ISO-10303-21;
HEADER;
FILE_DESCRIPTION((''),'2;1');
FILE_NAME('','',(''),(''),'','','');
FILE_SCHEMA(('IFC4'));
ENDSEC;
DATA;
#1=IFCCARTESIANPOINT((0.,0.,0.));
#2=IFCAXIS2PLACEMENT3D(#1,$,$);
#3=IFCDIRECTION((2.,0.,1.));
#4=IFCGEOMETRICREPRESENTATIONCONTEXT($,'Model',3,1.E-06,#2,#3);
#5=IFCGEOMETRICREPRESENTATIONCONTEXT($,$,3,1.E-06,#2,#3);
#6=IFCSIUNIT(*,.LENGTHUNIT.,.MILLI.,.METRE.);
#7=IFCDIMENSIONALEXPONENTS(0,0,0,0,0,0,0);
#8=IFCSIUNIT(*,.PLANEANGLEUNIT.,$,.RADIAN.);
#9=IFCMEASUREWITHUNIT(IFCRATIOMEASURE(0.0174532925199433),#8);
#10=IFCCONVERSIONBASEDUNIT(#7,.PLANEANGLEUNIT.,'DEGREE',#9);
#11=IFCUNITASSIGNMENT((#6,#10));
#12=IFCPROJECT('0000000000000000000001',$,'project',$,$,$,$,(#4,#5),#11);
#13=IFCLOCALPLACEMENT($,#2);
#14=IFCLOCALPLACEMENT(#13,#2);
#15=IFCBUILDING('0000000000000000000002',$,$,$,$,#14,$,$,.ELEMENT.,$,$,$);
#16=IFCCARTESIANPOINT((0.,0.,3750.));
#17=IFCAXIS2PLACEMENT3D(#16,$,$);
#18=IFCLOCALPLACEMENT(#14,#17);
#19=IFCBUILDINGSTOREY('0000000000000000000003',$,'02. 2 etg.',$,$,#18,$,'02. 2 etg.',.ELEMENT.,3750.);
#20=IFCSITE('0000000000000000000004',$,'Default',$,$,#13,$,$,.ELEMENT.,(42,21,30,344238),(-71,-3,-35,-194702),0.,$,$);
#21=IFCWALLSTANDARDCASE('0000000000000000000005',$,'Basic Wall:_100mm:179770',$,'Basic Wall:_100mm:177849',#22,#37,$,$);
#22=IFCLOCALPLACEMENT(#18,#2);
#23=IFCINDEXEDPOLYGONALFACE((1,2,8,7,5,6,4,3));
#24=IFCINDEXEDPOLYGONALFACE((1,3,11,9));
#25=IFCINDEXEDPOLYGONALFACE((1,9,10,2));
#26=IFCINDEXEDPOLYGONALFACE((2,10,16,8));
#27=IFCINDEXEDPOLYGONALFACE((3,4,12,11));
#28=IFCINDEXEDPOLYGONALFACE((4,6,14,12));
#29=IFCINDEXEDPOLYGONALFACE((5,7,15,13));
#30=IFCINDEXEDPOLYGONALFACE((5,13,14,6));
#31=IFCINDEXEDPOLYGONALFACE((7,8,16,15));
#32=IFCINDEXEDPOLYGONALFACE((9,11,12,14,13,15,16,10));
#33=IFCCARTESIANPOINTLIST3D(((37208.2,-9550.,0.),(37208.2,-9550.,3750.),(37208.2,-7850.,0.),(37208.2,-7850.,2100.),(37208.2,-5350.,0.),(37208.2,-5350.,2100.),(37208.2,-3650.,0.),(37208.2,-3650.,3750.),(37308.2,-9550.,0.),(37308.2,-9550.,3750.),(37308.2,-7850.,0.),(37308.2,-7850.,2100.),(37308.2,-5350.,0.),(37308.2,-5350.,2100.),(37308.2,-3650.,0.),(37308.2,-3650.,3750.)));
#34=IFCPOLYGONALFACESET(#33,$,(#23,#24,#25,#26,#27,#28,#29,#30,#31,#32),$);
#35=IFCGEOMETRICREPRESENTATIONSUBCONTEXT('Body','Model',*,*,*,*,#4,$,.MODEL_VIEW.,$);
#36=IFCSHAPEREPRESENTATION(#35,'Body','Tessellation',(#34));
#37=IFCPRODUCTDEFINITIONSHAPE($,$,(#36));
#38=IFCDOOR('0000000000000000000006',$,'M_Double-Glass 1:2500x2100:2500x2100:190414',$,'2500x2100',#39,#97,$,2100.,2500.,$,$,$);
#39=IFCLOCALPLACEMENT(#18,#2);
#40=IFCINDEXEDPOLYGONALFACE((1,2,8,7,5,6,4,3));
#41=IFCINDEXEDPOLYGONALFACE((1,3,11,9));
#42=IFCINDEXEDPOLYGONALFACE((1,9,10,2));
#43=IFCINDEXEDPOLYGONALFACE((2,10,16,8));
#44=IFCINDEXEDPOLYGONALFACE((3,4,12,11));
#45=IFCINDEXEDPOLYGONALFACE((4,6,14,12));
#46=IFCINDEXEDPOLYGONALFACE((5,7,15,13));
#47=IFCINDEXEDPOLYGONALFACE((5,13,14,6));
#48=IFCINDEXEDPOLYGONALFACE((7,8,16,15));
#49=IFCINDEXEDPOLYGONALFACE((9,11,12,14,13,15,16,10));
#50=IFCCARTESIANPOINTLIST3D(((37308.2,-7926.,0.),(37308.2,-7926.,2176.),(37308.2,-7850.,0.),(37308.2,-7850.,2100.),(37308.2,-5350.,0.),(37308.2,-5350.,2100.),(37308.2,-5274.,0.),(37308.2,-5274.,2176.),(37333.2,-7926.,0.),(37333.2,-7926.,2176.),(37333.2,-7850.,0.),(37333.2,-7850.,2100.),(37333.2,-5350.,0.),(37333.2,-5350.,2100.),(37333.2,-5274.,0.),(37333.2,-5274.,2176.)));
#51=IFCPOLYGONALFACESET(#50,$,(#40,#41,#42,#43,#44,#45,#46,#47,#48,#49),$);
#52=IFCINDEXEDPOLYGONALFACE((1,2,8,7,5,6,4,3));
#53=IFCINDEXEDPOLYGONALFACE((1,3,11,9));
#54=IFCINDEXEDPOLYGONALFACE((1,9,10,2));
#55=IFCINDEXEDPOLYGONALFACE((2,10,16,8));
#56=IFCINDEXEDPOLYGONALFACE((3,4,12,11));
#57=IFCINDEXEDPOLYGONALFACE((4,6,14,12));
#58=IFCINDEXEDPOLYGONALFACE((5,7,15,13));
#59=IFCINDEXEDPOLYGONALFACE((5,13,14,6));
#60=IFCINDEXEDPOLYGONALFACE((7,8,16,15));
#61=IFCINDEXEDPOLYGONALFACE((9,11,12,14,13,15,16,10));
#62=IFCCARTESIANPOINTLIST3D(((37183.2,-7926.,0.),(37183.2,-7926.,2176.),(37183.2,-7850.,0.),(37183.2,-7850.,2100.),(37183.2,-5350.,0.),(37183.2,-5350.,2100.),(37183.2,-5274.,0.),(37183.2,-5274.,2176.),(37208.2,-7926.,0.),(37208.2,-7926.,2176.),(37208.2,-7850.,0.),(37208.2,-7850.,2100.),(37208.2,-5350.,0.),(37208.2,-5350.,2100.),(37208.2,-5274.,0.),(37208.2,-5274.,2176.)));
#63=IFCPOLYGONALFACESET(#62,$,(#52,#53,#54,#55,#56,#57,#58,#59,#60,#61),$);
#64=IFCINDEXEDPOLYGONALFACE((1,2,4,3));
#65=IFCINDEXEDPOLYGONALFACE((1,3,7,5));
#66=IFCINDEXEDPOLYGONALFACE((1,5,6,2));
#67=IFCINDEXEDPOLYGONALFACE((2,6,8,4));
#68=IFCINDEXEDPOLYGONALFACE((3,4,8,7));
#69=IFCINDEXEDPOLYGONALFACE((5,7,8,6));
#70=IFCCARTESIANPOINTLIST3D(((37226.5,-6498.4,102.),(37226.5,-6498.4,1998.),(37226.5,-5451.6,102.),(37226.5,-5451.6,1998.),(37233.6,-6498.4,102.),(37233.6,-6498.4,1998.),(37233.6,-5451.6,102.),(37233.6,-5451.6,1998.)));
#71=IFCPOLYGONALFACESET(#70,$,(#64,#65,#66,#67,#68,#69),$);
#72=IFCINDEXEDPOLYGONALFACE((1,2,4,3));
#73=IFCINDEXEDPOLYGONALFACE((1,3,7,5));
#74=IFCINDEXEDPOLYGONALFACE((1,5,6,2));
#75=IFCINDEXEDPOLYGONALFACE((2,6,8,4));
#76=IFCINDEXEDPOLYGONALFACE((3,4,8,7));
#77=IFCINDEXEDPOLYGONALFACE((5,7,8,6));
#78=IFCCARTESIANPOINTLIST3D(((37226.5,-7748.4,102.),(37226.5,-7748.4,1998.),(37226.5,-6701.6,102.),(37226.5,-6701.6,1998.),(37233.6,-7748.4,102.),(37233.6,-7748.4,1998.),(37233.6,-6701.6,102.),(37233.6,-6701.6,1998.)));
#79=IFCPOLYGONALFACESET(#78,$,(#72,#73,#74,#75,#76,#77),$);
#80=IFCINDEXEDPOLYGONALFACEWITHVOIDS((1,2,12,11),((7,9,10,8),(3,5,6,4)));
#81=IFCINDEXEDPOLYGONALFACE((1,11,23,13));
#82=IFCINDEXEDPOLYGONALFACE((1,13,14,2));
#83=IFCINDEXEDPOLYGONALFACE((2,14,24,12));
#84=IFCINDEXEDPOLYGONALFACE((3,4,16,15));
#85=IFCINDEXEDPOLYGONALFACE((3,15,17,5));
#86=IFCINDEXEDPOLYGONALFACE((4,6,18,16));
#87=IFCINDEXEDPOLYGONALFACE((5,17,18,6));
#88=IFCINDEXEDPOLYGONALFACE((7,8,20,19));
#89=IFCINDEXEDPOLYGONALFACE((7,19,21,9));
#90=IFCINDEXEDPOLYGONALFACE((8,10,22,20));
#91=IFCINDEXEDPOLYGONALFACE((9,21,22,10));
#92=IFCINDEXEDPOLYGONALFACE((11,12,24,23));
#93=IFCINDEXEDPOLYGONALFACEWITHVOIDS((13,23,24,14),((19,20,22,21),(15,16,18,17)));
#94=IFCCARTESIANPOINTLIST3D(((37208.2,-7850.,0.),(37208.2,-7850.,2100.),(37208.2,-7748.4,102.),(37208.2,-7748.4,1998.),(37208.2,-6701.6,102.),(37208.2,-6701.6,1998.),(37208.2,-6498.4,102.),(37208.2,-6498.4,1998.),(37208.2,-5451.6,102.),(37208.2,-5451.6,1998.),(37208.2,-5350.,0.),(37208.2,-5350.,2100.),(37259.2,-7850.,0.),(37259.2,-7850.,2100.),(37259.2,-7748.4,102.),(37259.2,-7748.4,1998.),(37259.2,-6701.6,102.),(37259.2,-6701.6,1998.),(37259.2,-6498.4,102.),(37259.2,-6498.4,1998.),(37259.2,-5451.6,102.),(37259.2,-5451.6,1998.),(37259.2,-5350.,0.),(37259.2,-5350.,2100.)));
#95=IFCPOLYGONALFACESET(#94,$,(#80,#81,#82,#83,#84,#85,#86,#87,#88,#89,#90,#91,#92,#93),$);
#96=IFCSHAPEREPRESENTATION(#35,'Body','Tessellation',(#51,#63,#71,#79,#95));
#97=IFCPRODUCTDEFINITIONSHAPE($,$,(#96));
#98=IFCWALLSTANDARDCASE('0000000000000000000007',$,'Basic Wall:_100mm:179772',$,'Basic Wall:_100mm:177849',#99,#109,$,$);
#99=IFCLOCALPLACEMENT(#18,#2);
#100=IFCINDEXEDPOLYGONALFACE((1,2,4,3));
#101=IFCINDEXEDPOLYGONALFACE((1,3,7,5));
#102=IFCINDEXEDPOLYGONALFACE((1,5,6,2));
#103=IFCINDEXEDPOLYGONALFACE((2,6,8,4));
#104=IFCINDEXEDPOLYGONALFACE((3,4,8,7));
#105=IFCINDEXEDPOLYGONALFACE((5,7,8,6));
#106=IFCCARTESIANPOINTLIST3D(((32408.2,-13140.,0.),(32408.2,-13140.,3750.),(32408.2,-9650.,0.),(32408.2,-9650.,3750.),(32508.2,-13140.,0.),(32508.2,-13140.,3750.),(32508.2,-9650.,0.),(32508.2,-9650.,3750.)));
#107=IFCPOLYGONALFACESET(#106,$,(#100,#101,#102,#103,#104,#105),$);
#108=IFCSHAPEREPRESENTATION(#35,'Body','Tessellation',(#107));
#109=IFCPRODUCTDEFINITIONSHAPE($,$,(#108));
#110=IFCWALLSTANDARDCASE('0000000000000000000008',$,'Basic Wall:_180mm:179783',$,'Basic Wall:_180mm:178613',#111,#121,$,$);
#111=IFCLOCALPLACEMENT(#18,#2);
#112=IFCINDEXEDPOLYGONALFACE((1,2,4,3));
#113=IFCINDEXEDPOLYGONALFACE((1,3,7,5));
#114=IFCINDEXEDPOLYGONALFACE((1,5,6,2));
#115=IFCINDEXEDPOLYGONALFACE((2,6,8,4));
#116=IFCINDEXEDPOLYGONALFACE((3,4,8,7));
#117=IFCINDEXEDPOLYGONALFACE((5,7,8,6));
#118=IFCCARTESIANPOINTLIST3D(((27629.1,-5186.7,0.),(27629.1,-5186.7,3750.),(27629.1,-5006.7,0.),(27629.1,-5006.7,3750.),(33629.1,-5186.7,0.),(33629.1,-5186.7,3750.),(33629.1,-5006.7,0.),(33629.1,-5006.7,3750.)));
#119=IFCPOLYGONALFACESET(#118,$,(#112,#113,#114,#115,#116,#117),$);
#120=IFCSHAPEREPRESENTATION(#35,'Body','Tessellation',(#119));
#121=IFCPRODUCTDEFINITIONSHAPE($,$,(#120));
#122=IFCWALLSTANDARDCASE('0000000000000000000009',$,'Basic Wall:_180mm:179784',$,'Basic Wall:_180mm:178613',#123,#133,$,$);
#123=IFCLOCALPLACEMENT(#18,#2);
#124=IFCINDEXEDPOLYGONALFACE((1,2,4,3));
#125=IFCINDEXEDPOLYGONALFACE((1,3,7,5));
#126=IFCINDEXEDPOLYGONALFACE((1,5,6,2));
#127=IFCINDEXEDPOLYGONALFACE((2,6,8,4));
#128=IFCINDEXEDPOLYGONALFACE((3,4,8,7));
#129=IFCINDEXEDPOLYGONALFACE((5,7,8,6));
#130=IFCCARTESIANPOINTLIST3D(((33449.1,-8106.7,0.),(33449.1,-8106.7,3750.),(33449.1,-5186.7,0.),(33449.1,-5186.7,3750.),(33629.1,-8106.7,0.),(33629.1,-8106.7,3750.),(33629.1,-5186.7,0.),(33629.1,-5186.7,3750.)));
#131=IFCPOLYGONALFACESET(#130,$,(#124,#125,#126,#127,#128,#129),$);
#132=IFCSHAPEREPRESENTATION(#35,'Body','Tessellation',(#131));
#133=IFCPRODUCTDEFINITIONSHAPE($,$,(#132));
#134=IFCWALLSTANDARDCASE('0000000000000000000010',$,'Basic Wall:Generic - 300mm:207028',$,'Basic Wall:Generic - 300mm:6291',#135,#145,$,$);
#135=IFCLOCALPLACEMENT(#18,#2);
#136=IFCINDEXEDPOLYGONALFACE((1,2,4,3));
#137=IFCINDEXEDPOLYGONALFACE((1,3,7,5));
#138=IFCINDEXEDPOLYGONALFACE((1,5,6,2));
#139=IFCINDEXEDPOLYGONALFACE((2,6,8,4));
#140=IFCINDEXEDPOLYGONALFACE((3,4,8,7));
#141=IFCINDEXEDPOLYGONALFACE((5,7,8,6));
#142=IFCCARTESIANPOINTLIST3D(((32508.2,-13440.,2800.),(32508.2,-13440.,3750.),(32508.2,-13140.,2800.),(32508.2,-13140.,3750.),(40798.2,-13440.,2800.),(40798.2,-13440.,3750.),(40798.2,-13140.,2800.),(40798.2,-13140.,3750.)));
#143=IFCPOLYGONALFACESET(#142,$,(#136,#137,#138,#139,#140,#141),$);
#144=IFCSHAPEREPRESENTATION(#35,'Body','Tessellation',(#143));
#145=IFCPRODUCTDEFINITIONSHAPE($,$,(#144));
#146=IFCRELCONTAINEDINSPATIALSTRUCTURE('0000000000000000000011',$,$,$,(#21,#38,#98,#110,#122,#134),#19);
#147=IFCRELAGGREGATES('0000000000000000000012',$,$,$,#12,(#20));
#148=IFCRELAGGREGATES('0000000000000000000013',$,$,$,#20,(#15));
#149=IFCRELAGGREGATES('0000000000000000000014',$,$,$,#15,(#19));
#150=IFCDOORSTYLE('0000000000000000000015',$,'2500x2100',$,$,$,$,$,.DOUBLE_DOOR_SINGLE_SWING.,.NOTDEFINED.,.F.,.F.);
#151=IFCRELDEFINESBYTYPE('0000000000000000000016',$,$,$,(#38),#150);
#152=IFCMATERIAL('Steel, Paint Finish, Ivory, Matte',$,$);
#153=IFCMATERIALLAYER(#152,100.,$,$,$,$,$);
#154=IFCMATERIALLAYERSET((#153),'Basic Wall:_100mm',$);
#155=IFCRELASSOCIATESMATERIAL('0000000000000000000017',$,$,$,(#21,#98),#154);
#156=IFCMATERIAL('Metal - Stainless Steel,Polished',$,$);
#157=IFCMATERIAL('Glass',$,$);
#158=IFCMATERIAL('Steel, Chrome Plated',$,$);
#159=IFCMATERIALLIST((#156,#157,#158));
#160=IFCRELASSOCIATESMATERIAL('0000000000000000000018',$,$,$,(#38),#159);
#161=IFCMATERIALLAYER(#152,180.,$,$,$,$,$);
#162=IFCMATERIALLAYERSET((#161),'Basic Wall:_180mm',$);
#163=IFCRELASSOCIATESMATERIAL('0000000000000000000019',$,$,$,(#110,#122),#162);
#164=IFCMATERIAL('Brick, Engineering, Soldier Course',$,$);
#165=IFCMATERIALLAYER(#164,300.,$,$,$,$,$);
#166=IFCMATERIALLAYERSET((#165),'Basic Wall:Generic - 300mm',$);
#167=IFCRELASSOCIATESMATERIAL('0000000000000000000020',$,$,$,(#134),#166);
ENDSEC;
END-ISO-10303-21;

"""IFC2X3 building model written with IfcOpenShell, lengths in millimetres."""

from ifc_helpers import new_model, entity, si_unit, converted_unit, direction, frame, frame_2d, origin, place, context, subcontext, project, spatial, polyline, rectangle, outline, extrude, source, transform, mapped, material, material_list, layer, layer_set, layer_usage, type_object, type_shapes, element, fill, save


model = new_model("IFC2X3")

# Units and contexts
model_context = context("Model", 3, precision=1e-06, world=origin(), true_north=direction((2.0, 0.0, 1.0)))
context_of_model = context(None, 3, precision=1e-06, world=origin(), true_north=direction((2.0, 0.0, 1.0)))
body_context = subcontext(model_context, "Body", "Model", "MODEL_VIEW")
ifc_project = project(units=[si_unit("LENGTHUNIT", "METRE", prefix="MILLI"), converted_unit("PLANEANGLEUNIT", "DEGREE", entity("IfcRatioMeasure", 0.0174532925199433), si_unit("PLANEANGLEUNIT", "RADIAN"), dimensions=[0, 0, 0, 0, 0, 0, 0])], contexts=[model_context, context_of_model])

# Site, building, storey
site_placement = place(None, origin())
site = spatial("IfcSite", under=ifc_project, at=site_placement, Name="Default", CompositionType="ELEMENT", RefLatitude=(42, 21, 30, 344238), RefLongitude=(-71, -3, -35, -194702), RefElevation=0.0)
building_placement = place(site_placement, origin())
building = spatial("IfcBuilding", under=site, at=building_placement, CompositionType="ELEMENT")
storey_placement = place(building_placement, frame((0.0, 0.0, 3750.0)))
storey = spatial("IfcBuildingStorey", under=building, at=storey_placement, Name="02. 2 etg.", LongName="02. 2 etg.", CompositionType="ELEMENT", Elevation=3750.0)

# Shared definitions
ifc_material_1 = material(Name="Glass")

# Wall, opening, door
ifc_material_2 = material(Name="Steel, Paint Finish, Ivory, Matte")
ifc_layer_1 = layer(ifc_material_2, 100.0)
ifc_layer_set_1 = layer_set([ifc_layer_1], Name="Basic Wall:_100mm")
ifc_layer_usage_1 = layer_usage(ifc_layer_set_1, "AXIS2", "POSITIVE", -50.0)
wall_1_placement = place(storey_placement, frame((37258.2, -9550.0, 0.0), z_axis=(0.0, 0.0, 1.0), x_axis=(0.0, 1.0, 0.0)))
wall_1 = element("IfcWallStandardCase", 1, at=wall_1_placement, inside=storey, material=ifc_layer_usage_1, Name="Basic Wall:_100mm:179770", ObjectType="Basic Wall:_100mm:177849", context=body_context, shape_type="SweptSolid", body=[
    extrude(rectangle(XDim=5900.0, YDim=100.0, at=frame_2d((2950.0, 0.0), x_axis=(-1.0, 0.0))), origin(), (0.0, 0.0, 1.0), 3750.0),
])
opening_placement = place(wall_1_placement, frame((1700.0, -50.0, 0.0)))
opening = element("IfcOpeningElement", 2, at=opening_placement, cuts=wall_1, ObjectType="Opening", context=body_context, shape_type="SweptSolid", body=[
    extrude(rectangle(XDim=2500.0, YDim=2100.0, at=frame_2d((1050.0, 1250.0), x_axis=(0.0, 1.0))), frame((0.0, 0.0, 0.0), z_axis=(0.0, 1.0, 0.0), x_axis=(0.0, 0.0, 1.0)), (0.0, 0.0, 1.0), 100.0),
])
ifc_material_3 = material(Name="Metal - Stainless Steel,Polished")
ifc_material_4 = material(Name="Steel, Chrome Plated")
ifc_material_list = material_list([ifc_material_3, ifc_material_1, ifc_material_4])
door_style = type_object("IfcDoorStyle", Name="2500x2100", ConstructionType="NOTDEFINED", OperationType="DOUBLE_DOOR_SINGLE_SWING", ParameterTakesPrecedence=False, Sizeable=False)
shared_shape_1 = source(origin(), body_context, "Body", "SweptSolid", [
    extrude(outline(polyline([(-1326.0, -1069.0), (-1250.0, -1069.0), (-1250.0, 1031.0), (1250.0, 1031.0), (1250.0, -1069.0), (1326.0, -1069.0), (1326.0, 1107.0), (-1326.0, 1107.0), (-1326.0, -1069.0)])), frame((1250.0, -25.0, 1069.0), z_axis=(0.0, 1.0, 0.0), x_axis=(-1.0, 0.0, 0.0)), (0.0, 0.0, 1.0), 25.0),
    extrude(outline(polyline([(-1250.0, -1031.0), (-1250.0, 1069.0), (-1326.0, 1069.0), (-1326.0, -1107.0), (1326.0, -1107.0), (1326.0, 1069.0), (1250.0, 1069.0), (1250.0, -1031.0), (-1250.0, -1031.0)])), frame((1250.0, 100.0, 1069.0), z_axis=(0.0, -1.0, 0.0), x_axis=(-1.0, 0.0, 0.0)), (0.0, 0.0, -1.0), 25.0),
    extrude(rectangle(XDim=7.1, YDim=1046.8, at=frame_2d((0.0, 0.0), x_axis=(1.0, 0.0))), frame((1875.0, 78.2, 102.0), z_axis=(0.0, 0.0, 1.0), x_axis=(0.0, 1.0, 0.0)), (0.0, 0.0, 1.0), 1896.0),
    extrude(rectangle(XDim=7.1, YDim=1046.8, at=frame_2d((0.0, 0.0), x_axis=(1.0, 0.0))), frame((625.0, 78.2, 102.0), z_axis=(0.0, 0.0, 1.0), x_axis=(0.0, 1.0, 0.0)), (0.0, 0.0, 1.0), 1896.0),
    extrude(outline(polyline([(-1050.0, -1250.0), (1050.0, -1250.0), (1050.0, 1250.0), (-1050.0, 1250.0), (-1050.0, -1250.0)]), holes=[polyline([(-948.0, 101.6), (-948.0, 1148.4), (948.0, 1148.4), (948.0, 101.6), (-948.0, 101.6)]), polyline([(-948.0, -1148.4), (-948.0, -101.6), (948.0, -101.6), (948.0, -1148.4), (-948.0, -1148.4)])]), frame((1250.0, 49.0, 1050.0), z_axis=(0.0, 1.0, 0.0), x_axis=(0.0, 0.0, -1.0)), (0.0, 0.0, 1.0), 51.0),
])
type_shapes(door_style, [shared_shape_1])
door_placement = place(opening_placement, origin())
door = element("IfcDoor", 3, at=door_placement, inside=storey, type_object=door_style, material=ifc_material_list, Name="M_Double-Glass 1:2500x2100:2500x2100:190414", ObjectType="2500x2100", OverallHeight=2100.0, OverallWidth=2500.0, context=body_context, shape_type="MappedRepresentation", body=[
    mapped(shared_shape_1, transform((0.0, 0.0, 0.0), scale=1.0)),
])
fill(opening, door)

# Walls
ifc_layer_usage_2 = layer_usage(ifc_layer_set_1, "AXIS2", "POSITIVE", -50.0)
wall_2_placement = place(storey_placement, frame((32458.2, -13140.0, 0.0), z_axis=(0.0, 0.0, 1.0), x_axis=(0.0, 1.0, 0.0)))
element("IfcWallStandardCase", 4, at=wall_2_placement, inside=storey, material=ifc_layer_usage_2, Name="Basic Wall:_100mm:179772", ObjectType="Basic Wall:_100mm:177849", context=body_context, shape_type="SweptSolid", body=[
    extrude(rectangle(XDim=3490.0, YDim=100.0, at=frame_2d((1745.0, 0.0), x_axis=(-1.0, 0.0))), origin(), (0.0, 0.0, 1.0), 3750.0),
])
ifc_layer_2 = layer(ifc_material_2, 180.0)
ifc_layer_set_2 = layer_set([ifc_layer_2], Name="Basic Wall:_180mm")
ifc_layer_usage_3 = layer_usage(ifc_layer_set_2, "AXIS2", "POSITIVE", -90.0)
wall_3_placement = place(storey_placement, frame((33629.1, -5096.7, 0.0), z_axis=(0.0, 0.0, 1.0), x_axis=(-1.0, 0.0, 0.0)))
element("IfcWallStandardCase", 5, at=wall_3_placement, inside=storey, material=ifc_layer_usage_3, Name="Basic Wall:_180mm:179783", ObjectType="Basic Wall:_180mm:178613", context=body_context, shape_type="SweptSolid", body=[
    extrude(rectangle(XDim=6000.0, YDim=180.0, at=frame_2d((3000.0, 0.0), x_axis=(-1.0, 0.0))), origin(), (0.0, 0.0, 1.0), 3750.0),
])
ifc_layer_usage_4 = layer_usage(ifc_layer_set_2, "AXIS2", "POSITIVE", -90.0)
wall_4_placement = place(storey_placement, frame((33539.1, -8106.7, 0.0), z_axis=(0.0, 0.0, 1.0), x_axis=(0.0, 1.0, 0.0)))
element("IfcWallStandardCase", 6, at=wall_4_placement, inside=storey, material=ifc_layer_usage_4, Name="Basic Wall:_180mm:179784", ObjectType="Basic Wall:_180mm:178613", context=body_context, shape_type="SweptSolid", body=[
    extrude(rectangle(XDim=2920.0, YDim=180.0, at=frame_2d((1460.0, 0.0), x_axis=(-1.0, 0.0))), origin(), (0.0, 0.0, 1.0), 3750.0),
])
ifc_material_5 = material(Name="Brick, Engineering, Soldier Course")
ifc_layer_3 = layer(ifc_material_5, 300.0)
ifc_layer_set_3 = layer_set([ifc_layer_3], Name="Basic Wall:Generic - 300mm")
ifc_layer_usage_5 = layer_usage(ifc_layer_set_3, "AXIS2", "NEGATIVE", 150.0)
wall_5_placement = place(storey_placement, frame((32508.2, -13290.0, 2800.0)))
element("IfcWallStandardCase", 7, at=wall_5_placement, inside=storey, material=ifc_layer_usage_5, Name="Basic Wall:Generic - 300mm:207028", ObjectType="Basic Wall:Generic - 300mm:6291", context=body_context, shape_type="SweptSolid", body=[
    extrude(rectangle(XDim=8290.0, YDim=300.0, at=frame_2d((4145.0, 0.0), x_axis=(-1.0, 0.0))), origin(), (0.0, 0.0, 1.0), 950.0),
])

save(model, "model.ifc")
